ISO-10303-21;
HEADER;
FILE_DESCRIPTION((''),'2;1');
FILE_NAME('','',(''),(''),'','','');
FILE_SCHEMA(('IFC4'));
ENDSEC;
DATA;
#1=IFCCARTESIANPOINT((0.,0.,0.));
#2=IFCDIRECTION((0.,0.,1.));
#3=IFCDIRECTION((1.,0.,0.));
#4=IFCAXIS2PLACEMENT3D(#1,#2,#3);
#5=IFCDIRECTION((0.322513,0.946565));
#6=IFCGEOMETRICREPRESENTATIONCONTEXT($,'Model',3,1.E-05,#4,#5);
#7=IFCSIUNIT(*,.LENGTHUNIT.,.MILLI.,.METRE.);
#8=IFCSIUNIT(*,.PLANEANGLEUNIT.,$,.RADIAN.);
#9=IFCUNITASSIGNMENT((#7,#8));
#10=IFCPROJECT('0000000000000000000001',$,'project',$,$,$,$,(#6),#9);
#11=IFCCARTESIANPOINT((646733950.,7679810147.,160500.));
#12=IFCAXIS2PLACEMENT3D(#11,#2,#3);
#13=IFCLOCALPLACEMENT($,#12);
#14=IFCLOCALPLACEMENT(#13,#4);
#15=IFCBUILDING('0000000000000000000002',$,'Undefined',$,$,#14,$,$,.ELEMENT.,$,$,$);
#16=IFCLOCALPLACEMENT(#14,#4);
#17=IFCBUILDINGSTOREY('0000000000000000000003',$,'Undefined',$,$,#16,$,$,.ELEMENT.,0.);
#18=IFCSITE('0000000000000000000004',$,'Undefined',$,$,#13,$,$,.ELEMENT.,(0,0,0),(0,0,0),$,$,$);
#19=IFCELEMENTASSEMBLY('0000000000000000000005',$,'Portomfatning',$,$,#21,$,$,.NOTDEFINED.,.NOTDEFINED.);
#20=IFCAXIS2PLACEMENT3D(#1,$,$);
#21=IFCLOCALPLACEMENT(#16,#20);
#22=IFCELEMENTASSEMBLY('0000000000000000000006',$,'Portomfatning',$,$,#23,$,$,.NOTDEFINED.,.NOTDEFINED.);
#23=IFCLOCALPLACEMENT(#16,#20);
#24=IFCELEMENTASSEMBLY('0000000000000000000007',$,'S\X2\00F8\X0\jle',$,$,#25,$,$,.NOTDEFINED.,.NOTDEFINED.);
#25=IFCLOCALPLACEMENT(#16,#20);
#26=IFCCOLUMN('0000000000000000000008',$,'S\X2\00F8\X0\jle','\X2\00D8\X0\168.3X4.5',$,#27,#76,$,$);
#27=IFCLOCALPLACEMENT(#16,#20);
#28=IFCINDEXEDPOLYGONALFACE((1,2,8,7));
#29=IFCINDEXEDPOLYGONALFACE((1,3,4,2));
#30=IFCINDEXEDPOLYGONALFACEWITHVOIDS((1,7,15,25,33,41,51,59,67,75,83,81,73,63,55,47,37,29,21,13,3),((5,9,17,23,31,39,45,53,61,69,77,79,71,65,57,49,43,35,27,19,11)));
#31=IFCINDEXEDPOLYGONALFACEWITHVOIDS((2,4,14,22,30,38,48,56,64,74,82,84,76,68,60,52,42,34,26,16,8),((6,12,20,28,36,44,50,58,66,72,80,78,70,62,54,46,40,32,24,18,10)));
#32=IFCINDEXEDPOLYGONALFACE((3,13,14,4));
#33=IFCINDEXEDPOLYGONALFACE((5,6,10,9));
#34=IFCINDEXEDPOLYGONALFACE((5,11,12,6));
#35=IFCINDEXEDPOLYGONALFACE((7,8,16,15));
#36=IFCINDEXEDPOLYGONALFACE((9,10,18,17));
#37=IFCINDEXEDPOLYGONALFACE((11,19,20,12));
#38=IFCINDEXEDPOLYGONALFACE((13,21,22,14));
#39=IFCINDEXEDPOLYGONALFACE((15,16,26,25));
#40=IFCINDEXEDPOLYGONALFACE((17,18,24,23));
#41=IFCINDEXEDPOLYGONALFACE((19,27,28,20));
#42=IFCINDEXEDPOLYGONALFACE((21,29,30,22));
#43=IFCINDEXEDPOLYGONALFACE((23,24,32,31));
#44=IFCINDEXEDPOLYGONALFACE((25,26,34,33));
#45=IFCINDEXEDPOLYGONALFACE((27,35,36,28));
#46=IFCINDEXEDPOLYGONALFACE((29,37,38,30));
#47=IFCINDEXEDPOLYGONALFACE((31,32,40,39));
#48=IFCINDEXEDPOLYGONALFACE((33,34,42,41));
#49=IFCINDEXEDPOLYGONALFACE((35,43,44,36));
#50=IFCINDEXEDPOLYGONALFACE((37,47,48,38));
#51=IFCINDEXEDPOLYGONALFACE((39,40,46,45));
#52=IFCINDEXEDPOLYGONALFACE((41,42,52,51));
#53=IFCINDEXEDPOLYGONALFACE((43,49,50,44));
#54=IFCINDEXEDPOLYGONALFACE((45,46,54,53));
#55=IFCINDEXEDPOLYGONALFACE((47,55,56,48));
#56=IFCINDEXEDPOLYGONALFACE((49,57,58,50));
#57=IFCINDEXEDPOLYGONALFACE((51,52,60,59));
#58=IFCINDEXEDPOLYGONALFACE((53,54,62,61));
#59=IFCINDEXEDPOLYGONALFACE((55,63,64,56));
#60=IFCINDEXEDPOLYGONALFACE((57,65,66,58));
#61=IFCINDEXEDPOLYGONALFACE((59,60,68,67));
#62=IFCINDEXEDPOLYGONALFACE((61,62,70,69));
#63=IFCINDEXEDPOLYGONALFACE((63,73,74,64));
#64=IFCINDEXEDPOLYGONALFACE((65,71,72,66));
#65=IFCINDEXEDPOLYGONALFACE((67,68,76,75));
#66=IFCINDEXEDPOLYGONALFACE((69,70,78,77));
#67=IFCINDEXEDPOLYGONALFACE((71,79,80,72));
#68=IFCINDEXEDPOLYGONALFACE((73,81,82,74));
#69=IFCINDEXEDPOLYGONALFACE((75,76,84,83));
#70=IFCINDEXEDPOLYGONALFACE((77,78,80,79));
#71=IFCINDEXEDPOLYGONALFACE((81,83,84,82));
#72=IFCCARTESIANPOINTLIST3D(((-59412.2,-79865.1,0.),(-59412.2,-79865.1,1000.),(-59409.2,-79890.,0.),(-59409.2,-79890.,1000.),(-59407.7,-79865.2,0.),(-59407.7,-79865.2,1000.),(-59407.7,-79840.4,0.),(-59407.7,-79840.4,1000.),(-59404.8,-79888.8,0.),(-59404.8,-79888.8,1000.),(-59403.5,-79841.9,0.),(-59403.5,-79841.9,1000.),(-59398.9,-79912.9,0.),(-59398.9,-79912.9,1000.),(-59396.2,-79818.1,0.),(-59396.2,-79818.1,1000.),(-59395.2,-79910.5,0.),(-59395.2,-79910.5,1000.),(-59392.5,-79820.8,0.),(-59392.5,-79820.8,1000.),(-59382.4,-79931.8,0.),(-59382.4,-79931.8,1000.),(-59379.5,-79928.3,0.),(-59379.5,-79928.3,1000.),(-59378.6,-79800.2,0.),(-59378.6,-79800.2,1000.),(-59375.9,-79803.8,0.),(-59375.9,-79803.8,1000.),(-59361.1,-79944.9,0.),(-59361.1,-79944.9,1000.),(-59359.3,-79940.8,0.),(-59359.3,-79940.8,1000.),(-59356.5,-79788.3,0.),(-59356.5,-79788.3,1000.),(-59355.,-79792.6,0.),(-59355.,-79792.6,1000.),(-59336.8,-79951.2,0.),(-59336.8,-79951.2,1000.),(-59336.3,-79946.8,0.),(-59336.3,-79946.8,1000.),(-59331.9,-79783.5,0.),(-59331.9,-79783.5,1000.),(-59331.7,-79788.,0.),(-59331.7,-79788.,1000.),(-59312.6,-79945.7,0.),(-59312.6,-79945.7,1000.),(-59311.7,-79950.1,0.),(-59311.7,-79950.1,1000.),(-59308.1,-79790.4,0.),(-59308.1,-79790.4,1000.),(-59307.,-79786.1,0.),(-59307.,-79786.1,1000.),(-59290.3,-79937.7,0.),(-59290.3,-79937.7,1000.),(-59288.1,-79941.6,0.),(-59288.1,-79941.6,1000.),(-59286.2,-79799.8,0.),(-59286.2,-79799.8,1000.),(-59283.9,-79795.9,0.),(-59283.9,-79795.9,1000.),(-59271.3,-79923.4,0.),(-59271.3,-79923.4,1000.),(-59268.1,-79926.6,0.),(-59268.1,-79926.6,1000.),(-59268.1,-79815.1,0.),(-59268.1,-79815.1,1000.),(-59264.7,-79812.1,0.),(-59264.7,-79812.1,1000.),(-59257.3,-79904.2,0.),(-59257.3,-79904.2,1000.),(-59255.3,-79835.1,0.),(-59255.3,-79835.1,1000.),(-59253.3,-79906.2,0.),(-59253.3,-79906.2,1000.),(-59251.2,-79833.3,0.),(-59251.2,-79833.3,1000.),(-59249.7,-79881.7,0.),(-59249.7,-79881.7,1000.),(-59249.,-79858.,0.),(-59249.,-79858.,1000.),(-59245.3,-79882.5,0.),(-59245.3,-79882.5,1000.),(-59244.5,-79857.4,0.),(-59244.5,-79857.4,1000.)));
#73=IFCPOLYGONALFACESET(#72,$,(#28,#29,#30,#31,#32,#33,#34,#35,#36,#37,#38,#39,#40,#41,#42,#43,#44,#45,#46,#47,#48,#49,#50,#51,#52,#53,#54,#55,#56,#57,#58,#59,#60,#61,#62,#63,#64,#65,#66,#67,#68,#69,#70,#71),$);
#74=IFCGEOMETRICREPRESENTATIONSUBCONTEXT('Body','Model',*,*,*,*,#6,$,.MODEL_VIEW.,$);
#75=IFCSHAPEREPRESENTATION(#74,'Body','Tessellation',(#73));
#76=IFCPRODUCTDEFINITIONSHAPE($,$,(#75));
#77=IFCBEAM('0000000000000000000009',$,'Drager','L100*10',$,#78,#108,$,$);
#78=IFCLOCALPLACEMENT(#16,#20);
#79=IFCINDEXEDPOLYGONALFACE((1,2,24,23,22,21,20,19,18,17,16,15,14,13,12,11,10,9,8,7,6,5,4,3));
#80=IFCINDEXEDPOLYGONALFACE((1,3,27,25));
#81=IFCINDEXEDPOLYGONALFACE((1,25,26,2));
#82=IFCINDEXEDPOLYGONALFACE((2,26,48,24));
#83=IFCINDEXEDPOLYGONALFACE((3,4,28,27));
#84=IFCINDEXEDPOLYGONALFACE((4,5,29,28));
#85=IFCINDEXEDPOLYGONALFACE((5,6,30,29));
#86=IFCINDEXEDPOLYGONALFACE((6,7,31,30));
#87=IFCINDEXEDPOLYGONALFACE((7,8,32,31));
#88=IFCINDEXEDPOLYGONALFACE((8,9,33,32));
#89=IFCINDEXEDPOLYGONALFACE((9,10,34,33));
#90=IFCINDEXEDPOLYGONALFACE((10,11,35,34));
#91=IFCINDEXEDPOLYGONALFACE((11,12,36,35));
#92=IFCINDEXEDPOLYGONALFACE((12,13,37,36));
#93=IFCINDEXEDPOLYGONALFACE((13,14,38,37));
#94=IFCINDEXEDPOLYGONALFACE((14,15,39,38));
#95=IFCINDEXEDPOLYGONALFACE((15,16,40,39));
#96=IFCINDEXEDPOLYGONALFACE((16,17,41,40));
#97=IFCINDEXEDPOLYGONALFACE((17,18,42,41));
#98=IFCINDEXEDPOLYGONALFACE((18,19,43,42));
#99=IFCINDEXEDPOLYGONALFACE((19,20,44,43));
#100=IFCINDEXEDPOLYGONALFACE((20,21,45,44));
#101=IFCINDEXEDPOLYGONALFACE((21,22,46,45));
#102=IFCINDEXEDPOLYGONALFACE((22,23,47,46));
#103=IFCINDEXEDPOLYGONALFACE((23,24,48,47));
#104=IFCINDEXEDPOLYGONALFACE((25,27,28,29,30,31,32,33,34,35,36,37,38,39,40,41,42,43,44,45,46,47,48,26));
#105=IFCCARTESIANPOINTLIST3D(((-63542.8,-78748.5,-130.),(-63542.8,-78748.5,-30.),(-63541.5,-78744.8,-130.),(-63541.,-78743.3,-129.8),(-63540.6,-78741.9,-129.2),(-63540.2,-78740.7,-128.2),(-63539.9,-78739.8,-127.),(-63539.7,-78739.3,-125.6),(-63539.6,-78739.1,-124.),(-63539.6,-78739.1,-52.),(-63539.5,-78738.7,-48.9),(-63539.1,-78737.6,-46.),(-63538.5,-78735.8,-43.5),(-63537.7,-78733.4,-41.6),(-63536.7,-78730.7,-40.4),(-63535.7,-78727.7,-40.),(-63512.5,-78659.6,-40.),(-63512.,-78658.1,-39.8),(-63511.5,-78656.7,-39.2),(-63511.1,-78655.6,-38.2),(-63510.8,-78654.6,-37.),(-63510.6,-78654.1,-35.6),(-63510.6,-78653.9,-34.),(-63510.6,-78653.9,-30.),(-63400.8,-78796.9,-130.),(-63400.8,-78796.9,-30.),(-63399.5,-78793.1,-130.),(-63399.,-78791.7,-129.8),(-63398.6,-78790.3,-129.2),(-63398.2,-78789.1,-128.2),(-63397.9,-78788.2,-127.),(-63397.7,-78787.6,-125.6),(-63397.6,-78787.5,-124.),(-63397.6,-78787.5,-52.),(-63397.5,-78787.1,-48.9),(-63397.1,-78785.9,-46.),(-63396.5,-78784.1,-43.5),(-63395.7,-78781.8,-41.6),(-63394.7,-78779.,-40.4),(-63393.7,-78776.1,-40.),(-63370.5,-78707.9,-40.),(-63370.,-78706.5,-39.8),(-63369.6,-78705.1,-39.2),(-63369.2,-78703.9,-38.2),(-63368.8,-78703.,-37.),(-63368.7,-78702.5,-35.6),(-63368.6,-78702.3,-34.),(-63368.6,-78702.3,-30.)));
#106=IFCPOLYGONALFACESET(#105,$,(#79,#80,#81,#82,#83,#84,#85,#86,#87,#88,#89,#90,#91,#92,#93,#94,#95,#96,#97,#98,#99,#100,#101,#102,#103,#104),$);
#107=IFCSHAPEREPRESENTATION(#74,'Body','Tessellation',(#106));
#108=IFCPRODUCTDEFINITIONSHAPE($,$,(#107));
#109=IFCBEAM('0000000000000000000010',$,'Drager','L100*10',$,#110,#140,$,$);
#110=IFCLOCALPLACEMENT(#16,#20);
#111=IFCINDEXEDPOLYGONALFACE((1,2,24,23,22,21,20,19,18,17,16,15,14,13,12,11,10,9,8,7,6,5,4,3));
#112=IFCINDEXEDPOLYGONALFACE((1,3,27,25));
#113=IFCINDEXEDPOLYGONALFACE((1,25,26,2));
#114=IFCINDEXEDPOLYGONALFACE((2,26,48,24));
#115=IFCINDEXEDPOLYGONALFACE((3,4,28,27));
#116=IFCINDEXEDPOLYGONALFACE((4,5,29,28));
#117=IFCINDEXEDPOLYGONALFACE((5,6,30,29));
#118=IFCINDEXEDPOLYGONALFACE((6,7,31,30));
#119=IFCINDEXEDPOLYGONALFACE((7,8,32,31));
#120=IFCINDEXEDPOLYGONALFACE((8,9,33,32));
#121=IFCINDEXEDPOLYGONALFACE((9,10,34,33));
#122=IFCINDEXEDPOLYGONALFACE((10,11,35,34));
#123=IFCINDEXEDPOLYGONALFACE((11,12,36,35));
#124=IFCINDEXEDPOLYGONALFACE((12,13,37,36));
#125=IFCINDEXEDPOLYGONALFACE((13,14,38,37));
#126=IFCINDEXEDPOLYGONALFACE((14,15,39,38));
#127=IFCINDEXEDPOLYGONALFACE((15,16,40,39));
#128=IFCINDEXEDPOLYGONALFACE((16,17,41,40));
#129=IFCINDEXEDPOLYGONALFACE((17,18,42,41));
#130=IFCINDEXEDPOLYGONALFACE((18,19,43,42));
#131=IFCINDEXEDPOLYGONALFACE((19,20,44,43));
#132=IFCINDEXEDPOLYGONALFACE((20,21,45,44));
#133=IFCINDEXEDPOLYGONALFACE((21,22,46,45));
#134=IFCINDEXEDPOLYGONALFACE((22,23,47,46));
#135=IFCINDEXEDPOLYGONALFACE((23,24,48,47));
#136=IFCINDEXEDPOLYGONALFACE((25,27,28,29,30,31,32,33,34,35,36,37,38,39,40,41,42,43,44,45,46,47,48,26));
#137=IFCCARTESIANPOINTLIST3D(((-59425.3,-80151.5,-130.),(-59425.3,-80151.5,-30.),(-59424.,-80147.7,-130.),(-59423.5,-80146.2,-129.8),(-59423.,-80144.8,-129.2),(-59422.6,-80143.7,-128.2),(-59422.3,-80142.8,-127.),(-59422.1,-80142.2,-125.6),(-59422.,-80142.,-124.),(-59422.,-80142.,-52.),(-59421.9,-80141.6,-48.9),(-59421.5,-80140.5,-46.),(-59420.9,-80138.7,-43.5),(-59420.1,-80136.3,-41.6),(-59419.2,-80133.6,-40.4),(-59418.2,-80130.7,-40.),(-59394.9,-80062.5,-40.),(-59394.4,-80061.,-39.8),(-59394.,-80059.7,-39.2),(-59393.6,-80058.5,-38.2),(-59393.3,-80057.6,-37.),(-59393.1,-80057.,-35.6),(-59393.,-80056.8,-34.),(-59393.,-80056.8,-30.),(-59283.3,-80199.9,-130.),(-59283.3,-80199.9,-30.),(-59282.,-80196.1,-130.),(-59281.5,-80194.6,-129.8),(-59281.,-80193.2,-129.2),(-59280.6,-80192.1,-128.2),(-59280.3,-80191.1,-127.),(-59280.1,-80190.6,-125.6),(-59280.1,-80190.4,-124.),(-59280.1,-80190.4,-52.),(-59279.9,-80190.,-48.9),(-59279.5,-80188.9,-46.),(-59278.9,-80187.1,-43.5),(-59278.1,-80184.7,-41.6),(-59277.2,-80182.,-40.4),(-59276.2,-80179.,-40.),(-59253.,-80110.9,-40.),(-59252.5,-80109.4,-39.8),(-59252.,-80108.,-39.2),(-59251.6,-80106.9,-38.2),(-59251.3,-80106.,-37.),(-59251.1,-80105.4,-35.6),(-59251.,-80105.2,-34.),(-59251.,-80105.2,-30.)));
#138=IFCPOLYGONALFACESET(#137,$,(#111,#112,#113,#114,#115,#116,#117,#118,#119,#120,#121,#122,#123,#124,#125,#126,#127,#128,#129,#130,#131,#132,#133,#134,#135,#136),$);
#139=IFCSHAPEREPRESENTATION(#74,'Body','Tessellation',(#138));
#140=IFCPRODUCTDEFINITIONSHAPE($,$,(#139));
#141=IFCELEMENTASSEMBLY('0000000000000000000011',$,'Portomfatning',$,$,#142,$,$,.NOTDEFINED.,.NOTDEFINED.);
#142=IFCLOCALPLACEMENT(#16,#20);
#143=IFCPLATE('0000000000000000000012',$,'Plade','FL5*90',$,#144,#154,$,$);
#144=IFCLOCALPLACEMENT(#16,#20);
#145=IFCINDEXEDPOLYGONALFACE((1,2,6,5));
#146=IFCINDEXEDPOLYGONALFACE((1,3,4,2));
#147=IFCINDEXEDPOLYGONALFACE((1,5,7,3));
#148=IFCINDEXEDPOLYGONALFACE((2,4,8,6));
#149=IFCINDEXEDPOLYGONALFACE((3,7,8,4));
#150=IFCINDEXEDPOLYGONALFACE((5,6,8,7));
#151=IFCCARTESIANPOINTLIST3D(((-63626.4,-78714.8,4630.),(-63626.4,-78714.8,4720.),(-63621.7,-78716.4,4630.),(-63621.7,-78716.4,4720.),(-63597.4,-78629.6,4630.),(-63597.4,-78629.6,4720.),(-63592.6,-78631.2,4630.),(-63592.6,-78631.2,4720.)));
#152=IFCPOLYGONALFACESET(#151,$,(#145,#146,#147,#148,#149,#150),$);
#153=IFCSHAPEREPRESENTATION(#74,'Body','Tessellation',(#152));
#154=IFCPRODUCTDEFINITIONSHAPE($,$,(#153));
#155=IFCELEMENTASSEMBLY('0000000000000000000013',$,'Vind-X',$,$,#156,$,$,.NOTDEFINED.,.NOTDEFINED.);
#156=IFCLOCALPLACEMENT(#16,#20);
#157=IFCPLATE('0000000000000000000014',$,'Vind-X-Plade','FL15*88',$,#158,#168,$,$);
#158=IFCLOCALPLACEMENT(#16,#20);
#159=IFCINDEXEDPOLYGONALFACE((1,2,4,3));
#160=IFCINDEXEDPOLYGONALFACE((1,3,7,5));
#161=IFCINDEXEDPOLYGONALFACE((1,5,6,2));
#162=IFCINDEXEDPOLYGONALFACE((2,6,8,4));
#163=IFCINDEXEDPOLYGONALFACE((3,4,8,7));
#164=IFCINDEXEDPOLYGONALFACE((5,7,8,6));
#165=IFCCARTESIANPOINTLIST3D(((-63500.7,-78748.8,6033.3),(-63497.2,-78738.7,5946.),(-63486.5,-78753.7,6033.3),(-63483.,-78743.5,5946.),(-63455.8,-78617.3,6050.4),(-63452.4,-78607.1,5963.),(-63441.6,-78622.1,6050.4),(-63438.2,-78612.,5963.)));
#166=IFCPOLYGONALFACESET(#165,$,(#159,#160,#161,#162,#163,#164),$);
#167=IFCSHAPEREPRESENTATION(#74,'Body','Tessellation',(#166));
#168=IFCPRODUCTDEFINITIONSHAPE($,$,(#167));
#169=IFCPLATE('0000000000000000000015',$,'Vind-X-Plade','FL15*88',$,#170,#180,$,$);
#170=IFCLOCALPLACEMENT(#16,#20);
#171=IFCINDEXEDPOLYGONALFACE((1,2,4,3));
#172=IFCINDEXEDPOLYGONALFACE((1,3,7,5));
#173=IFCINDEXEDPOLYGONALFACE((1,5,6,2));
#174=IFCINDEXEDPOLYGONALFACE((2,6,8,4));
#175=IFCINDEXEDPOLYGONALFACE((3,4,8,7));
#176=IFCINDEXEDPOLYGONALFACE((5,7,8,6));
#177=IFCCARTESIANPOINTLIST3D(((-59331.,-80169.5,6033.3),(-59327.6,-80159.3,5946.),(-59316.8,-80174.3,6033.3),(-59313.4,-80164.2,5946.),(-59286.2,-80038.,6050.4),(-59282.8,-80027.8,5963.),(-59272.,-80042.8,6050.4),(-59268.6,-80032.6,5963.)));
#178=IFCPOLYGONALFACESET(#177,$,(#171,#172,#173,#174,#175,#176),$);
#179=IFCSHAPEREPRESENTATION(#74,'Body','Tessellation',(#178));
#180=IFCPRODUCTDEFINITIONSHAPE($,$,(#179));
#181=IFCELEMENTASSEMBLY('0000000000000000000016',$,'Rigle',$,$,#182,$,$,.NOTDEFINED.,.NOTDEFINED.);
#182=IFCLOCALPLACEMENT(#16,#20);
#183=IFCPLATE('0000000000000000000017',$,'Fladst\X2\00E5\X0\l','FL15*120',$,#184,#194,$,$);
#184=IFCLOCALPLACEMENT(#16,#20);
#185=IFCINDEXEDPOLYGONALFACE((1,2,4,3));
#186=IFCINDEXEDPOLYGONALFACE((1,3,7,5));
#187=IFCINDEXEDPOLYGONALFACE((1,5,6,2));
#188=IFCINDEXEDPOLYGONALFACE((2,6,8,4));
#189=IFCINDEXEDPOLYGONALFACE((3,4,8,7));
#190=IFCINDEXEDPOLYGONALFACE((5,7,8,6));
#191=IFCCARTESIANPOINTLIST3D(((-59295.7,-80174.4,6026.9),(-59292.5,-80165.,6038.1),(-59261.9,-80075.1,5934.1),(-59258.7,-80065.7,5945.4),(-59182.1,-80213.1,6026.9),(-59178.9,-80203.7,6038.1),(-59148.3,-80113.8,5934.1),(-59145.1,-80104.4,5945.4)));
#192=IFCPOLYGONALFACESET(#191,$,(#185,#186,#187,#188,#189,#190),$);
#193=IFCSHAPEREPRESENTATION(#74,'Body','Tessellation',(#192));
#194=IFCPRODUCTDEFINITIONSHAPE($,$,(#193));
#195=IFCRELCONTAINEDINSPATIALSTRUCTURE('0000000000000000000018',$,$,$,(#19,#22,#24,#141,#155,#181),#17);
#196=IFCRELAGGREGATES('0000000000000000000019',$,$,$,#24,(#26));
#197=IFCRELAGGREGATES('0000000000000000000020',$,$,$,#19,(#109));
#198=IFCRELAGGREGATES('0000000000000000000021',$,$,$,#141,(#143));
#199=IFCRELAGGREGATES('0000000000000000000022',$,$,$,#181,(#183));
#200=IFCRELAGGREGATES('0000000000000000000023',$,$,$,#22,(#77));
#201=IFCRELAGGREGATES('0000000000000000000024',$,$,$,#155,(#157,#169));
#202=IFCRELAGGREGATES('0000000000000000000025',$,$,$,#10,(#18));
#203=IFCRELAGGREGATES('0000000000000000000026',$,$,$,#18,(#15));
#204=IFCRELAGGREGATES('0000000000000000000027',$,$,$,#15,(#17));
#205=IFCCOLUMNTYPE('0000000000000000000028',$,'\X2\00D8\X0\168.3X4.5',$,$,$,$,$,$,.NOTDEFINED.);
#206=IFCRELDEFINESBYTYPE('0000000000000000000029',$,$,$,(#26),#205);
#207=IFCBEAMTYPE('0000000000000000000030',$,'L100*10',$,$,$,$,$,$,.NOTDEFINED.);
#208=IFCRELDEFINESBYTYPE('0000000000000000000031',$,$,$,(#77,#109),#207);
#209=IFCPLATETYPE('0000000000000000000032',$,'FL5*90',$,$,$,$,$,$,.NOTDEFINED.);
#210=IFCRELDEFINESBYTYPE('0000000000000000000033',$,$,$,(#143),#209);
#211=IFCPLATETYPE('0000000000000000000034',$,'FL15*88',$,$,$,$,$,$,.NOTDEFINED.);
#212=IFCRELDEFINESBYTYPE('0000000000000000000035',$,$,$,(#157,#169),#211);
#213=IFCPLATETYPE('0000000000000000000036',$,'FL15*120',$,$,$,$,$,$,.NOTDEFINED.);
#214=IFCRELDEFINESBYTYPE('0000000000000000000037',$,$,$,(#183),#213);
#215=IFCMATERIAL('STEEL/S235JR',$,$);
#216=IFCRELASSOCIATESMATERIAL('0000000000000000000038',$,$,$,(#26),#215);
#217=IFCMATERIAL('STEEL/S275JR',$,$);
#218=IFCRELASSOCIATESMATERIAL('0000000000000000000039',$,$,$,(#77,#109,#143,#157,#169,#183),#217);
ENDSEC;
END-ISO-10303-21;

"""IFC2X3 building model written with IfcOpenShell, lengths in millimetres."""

from ifc_helpers import new_model, si_unit, direction, frame, origin_with_axes, origin_2d_with_axis, place, context, subcontext, project, spatial, polyline, hollow_circle, l_section, outline, extrude, material, type_object, element, aggregate, save


model = new_model("IFC2X3")

# Units and contexts
model_context = context("Model", 3, precision=1e-05, world=origin_with_axes(), true_north=direction((0.322513, 0.946565)))
body_context = subcontext(model_context, "Body", "Model", "MODEL_VIEW")
ifc_project = project(units=[si_unit("LENGTHUNIT", "METRE", prefix="MILLI"), si_unit("PLANEANGLEUNIT", "RADIAN")], contexts=[model_context])

# Site, building, storey
site_placement = place(None, frame((646733950.0, 7679810147.0, 160500.0), z_axis=(0.0, 0.0, 1.0), x_axis=(1.0, 0.0, 0.0)))
site = spatial("IfcSite", under=ifc_project, at=site_placement, Name="Undefined", CompositionType="ELEMENT", RefLatitude=(0, 0, 0), RefLongitude=(0, 0, 0))
building_placement = place(site_placement, origin_with_axes())
building = spatial("IfcBuilding", under=site, at=building_placement, Name="Undefined", CompositionType="ELEMENT")
storey_placement = place(building_placement, origin_with_axes())
storey = spatial("IfcBuildingStorey", under=building, at=storey_placement, Name="Undefined", CompositionType="ELEMENT", Elevation=0.0)

# Element assemblies, column
assembly_1_placement = place(storey_placement, origin_with_axes())
assembly_1 = element("IfcElementAssembly", 1, at=assembly_1_placement, inside=storey, Name="Portomfatning", AssemblyPlace="NOTDEFINED", PredefinedType="NOTDEFINED")
assembly_2_placement = place(storey_placement, origin_with_axes())
assembly_2 = element("IfcElementAssembly", 2, at=assembly_2_placement, inside=storey, Name="Portomfatning", AssemblyPlace="NOTDEFINED", PredefinedType="NOTDEFINED")
ifc_material_1 = material(Name="STEEL/S235JR")
column_type_1 = type_object("IfcColumnType", Name="Ø168.3X4.5", PredefinedType="NOTDEFINED")
assembly_3_placement = place(storey_placement, origin_with_axes())
assembly_3 = element("IfcElementAssembly", 3, at=assembly_3_placement, inside=storey, Name="Søjle", AssemblyPlace="NOTDEFINED", PredefinedType="NOTDEFINED")
column_1_placement = place(assembly_3_placement, frame((-59328.1, -79867.5, 0.0), z_axis=(0.0, 0.0, 1.0), x_axis=(0.322513, 0.946565, 0.0)))
column_1 = element("IfcColumn", 4, at=column_1_placement, type_object=column_type_1, material=ifc_material_1, Name="Søjle", Description="Ø168.3X4.5", context=body_context, shape_type="SweptSolid", body=[
    extrude(hollow_circle(Radius=84.2, WallThickness=4.5, at=origin_2d_with_axis()), frame((0.0, 0.0, 1000.0), z_axis=(0.0, 0.0, -1.0), x_axis=(0.0, 1.0, 0.0)), (0.0, 0.0, 1.0), 1000.0),
])
aggregate(assembly_3, [column_1])

# Beams
ifc_material_2 = material(Name="STEEL/S275JR")
beam_type_1 = type_object("IfcBeamType", Name="L100*10", PredefinedType="NOTDEFINED")
beam_1_placement = place(assembly_2_placement, frame((-63526.7, -78701.2, -80.0), z_axis=(0.0, 0.0, -1.0), x_axis=(0.946565, -0.322513, 0.0)))
beam_1 = element("IfcBeam", 5, at=beam_1_placement, type_object=beam_type_1, material=ifc_material_2, Name="Drager", Description="L100*10", context=body_context, shape_type="SweptSolid", body=[
    extrude(l_section(Depth=100.0, Width=100.0, Thickness=10.0, FilletRadius=12.0, EdgeRadius=6.0, at=origin_2d_with_axis()), frame((150.0, 0.0, 0.0), z_axis=(-1.0, 0.0, 0.0), x_axis=(0.0, -1.0, 0.0)), (0.0, 0.0, 1.0), 150.0),
])
beam_2_placement = place(assembly_1_placement, frame((-59409.1, -80104.1, -80.0), z_axis=(0.0, 0.0, -1.0), x_axis=(0.946565, -0.322513, 0.0)))
beam_2 = element("IfcBeam", 6, at=beam_2_placement, type_object=beam_type_1, material=ifc_material_2, Name="Drager", Description="L100*10", context=body_context, shape_type="SweptSolid", body=[
    extrude(l_section(Depth=100.0, Width=100.0, Thickness=10.0, FilletRadius=12.0, EdgeRadius=6.0, at=origin_2d_with_axis()), frame((150.0, 0.0, 0.0), z_axis=(-1.0, 0.0, 0.0), x_axis=(0.0, -1.0, 0.0)), (0.0, 0.0, 1.0), 150.0),
])
aggregate(assembly_1, [beam_2])

# Element assembly, plate
assembly_4_placement = place(storey_placement, origin_with_axes())
assembly_4 = element("IfcElementAssembly", 7, at=assembly_4_placement, inside=storey, Name="Portomfatning", AssemblyPlace="NOTDEFINED", PredefinedType="NOTDEFINED")
plate_type_1 = type_object("IfcPlateType", Name="FL5*90", PredefinedType="NOTDEFINED")
plate_1_placement = place(assembly_4_placement, frame((-63624.1, -78715.6, 4630.0), z_axis=(-0.946505, 0.322688, 0.0), x_axis=(0.0, 0.0, 1.0)))
plate_1 = element("IfcPlate", 8, at=plate_1_placement, type_object=plate_type_1, material=ifc_material_2, Name="Plade", Description="FL5*90", context=body_context, shape_type="SweptSolid", body=[
    extrude(outline(polyline([(0.0, 0.0), (90.0, 0.0), (90.0, 90.0), (0.0, 90.0), (0.0, 0.0)])), frame((0.0, 0.0, -2.5), z_axis=(0.0, 0.0, 1.0), x_axis=(1.0, 0.0, 0.0)), (0.0, 0.0, 1.0), 5.0),
])
aggregate(assembly_4, [plate_1])

# Element assembly, plates
assembly_5_placement = place(storey_placement, origin_with_axes())
assembly_5 = element("IfcElementAssembly", 9, at=assembly_5_placement, inside=storey, Name="Vind-X", AssemblyPlace="NOTDEFINED", PredefinedType="NOTDEFINED")
plate_type_2 = type_object("IfcPlateType", Name="FL15*88", PredefinedType="NOTDEFINED")
plate_2_placement = place(assembly_5_placement, frame((-63445.3, -78609.6, 5963.0), z_axis=(-0.946565, 0.322513, 0.0), x_axis=(-0.320109, -0.93951, -0.121869)))
plate_2 = element("IfcPlate", 10, at=plate_2_placement, type_object=plate_type_2, material=ifc_material_2, Name="Vind-X-Plade", Description="FL15*88", context=body_context, shape_type="SweptSolid", body=[
    extrude(outline(polyline([(0.0, 0.0), (140.0, 0.0), (140.0, 88.0), (0.0, 88.0), (0.0, 0.0)])), frame((0.0, 0.0, -7.5), z_axis=(0.0, 0.0, 1.0), x_axis=(1.0, 0.0, 0.0)), (0.0, 0.0, 1.0), 15.0),
])
plate_3_placement = place(assembly_5_placement, frame((-59275.7, -80030.2, 5963.0), z_axis=(-0.946565, 0.322513, 0.0), x_axis=(-0.320109, -0.93951, -0.121869)))
plate_3 = element("IfcPlate", 11, at=plate_3_placement, type_object=plate_type_2, material=ifc_material_2, Name="Vind-X-Plade", Description="FL15*88", context=body_context, shape_type="SweptSolid", body=[
    extrude(outline(polyline([(0.0, 0.0), (140.0, 0.0), (140.0, 88.0), (0.0, 88.0), (0.0, 0.0)])), frame((0.0, 0.0, -7.5), z_axis=(0.0, 0.0, 1.0), x_axis=(1.0, 0.0, 0.0)), (0.0, 0.0, 1.0), 15.0),
])

# Element assembly, plate
assembly_6_placement = place(storey_placement, origin_with_axes())
assembly_6 = element("IfcElementAssembly", 12, at=assembly_6_placement, inside=storey, Name="Rigle", AssemblyPlace="NOTDEFINED", PredefinedType="NOTDEFINED")
plate_type_3 = type_object("IfcPlateType", Name="FL15*120", PredefinedType="NOTDEFINED")
plate_4_placement = place(assembly_6_placement, frame((-59146.7, -80109.1, 5939.7), z_axis=(-0.213703, -0.627213, -0.748956), x_axis=(-0.241548, -0.708935, 0.66262)))
plate_4 = element("IfcPlate", 13, at=plate_4_placement, type_object=plate_type_3, material=ifc_material_2, Name="Fladstål", Description="FL15*120", context=body_context, shape_type="SweptSolid", body=[
    extrude(outline(polyline([(0.0, 0.0), (140.0, 0.0), (140.0, 120.0), (0.0, 120.0), (0.0, 0.0)])), frame((0.0, 0.0, -7.5), z_axis=(0.0, 0.0, 1.0), x_axis=(1.0, 0.0, 0.0)), (0.0, 0.0, 1.0), 15.0),
])
aggregate(assembly_6, [plate_4])

aggregate(assembly_2, [beam_1])
aggregate(assembly_5, [plate_2, plate_3])

save(model, "model.ifc")
